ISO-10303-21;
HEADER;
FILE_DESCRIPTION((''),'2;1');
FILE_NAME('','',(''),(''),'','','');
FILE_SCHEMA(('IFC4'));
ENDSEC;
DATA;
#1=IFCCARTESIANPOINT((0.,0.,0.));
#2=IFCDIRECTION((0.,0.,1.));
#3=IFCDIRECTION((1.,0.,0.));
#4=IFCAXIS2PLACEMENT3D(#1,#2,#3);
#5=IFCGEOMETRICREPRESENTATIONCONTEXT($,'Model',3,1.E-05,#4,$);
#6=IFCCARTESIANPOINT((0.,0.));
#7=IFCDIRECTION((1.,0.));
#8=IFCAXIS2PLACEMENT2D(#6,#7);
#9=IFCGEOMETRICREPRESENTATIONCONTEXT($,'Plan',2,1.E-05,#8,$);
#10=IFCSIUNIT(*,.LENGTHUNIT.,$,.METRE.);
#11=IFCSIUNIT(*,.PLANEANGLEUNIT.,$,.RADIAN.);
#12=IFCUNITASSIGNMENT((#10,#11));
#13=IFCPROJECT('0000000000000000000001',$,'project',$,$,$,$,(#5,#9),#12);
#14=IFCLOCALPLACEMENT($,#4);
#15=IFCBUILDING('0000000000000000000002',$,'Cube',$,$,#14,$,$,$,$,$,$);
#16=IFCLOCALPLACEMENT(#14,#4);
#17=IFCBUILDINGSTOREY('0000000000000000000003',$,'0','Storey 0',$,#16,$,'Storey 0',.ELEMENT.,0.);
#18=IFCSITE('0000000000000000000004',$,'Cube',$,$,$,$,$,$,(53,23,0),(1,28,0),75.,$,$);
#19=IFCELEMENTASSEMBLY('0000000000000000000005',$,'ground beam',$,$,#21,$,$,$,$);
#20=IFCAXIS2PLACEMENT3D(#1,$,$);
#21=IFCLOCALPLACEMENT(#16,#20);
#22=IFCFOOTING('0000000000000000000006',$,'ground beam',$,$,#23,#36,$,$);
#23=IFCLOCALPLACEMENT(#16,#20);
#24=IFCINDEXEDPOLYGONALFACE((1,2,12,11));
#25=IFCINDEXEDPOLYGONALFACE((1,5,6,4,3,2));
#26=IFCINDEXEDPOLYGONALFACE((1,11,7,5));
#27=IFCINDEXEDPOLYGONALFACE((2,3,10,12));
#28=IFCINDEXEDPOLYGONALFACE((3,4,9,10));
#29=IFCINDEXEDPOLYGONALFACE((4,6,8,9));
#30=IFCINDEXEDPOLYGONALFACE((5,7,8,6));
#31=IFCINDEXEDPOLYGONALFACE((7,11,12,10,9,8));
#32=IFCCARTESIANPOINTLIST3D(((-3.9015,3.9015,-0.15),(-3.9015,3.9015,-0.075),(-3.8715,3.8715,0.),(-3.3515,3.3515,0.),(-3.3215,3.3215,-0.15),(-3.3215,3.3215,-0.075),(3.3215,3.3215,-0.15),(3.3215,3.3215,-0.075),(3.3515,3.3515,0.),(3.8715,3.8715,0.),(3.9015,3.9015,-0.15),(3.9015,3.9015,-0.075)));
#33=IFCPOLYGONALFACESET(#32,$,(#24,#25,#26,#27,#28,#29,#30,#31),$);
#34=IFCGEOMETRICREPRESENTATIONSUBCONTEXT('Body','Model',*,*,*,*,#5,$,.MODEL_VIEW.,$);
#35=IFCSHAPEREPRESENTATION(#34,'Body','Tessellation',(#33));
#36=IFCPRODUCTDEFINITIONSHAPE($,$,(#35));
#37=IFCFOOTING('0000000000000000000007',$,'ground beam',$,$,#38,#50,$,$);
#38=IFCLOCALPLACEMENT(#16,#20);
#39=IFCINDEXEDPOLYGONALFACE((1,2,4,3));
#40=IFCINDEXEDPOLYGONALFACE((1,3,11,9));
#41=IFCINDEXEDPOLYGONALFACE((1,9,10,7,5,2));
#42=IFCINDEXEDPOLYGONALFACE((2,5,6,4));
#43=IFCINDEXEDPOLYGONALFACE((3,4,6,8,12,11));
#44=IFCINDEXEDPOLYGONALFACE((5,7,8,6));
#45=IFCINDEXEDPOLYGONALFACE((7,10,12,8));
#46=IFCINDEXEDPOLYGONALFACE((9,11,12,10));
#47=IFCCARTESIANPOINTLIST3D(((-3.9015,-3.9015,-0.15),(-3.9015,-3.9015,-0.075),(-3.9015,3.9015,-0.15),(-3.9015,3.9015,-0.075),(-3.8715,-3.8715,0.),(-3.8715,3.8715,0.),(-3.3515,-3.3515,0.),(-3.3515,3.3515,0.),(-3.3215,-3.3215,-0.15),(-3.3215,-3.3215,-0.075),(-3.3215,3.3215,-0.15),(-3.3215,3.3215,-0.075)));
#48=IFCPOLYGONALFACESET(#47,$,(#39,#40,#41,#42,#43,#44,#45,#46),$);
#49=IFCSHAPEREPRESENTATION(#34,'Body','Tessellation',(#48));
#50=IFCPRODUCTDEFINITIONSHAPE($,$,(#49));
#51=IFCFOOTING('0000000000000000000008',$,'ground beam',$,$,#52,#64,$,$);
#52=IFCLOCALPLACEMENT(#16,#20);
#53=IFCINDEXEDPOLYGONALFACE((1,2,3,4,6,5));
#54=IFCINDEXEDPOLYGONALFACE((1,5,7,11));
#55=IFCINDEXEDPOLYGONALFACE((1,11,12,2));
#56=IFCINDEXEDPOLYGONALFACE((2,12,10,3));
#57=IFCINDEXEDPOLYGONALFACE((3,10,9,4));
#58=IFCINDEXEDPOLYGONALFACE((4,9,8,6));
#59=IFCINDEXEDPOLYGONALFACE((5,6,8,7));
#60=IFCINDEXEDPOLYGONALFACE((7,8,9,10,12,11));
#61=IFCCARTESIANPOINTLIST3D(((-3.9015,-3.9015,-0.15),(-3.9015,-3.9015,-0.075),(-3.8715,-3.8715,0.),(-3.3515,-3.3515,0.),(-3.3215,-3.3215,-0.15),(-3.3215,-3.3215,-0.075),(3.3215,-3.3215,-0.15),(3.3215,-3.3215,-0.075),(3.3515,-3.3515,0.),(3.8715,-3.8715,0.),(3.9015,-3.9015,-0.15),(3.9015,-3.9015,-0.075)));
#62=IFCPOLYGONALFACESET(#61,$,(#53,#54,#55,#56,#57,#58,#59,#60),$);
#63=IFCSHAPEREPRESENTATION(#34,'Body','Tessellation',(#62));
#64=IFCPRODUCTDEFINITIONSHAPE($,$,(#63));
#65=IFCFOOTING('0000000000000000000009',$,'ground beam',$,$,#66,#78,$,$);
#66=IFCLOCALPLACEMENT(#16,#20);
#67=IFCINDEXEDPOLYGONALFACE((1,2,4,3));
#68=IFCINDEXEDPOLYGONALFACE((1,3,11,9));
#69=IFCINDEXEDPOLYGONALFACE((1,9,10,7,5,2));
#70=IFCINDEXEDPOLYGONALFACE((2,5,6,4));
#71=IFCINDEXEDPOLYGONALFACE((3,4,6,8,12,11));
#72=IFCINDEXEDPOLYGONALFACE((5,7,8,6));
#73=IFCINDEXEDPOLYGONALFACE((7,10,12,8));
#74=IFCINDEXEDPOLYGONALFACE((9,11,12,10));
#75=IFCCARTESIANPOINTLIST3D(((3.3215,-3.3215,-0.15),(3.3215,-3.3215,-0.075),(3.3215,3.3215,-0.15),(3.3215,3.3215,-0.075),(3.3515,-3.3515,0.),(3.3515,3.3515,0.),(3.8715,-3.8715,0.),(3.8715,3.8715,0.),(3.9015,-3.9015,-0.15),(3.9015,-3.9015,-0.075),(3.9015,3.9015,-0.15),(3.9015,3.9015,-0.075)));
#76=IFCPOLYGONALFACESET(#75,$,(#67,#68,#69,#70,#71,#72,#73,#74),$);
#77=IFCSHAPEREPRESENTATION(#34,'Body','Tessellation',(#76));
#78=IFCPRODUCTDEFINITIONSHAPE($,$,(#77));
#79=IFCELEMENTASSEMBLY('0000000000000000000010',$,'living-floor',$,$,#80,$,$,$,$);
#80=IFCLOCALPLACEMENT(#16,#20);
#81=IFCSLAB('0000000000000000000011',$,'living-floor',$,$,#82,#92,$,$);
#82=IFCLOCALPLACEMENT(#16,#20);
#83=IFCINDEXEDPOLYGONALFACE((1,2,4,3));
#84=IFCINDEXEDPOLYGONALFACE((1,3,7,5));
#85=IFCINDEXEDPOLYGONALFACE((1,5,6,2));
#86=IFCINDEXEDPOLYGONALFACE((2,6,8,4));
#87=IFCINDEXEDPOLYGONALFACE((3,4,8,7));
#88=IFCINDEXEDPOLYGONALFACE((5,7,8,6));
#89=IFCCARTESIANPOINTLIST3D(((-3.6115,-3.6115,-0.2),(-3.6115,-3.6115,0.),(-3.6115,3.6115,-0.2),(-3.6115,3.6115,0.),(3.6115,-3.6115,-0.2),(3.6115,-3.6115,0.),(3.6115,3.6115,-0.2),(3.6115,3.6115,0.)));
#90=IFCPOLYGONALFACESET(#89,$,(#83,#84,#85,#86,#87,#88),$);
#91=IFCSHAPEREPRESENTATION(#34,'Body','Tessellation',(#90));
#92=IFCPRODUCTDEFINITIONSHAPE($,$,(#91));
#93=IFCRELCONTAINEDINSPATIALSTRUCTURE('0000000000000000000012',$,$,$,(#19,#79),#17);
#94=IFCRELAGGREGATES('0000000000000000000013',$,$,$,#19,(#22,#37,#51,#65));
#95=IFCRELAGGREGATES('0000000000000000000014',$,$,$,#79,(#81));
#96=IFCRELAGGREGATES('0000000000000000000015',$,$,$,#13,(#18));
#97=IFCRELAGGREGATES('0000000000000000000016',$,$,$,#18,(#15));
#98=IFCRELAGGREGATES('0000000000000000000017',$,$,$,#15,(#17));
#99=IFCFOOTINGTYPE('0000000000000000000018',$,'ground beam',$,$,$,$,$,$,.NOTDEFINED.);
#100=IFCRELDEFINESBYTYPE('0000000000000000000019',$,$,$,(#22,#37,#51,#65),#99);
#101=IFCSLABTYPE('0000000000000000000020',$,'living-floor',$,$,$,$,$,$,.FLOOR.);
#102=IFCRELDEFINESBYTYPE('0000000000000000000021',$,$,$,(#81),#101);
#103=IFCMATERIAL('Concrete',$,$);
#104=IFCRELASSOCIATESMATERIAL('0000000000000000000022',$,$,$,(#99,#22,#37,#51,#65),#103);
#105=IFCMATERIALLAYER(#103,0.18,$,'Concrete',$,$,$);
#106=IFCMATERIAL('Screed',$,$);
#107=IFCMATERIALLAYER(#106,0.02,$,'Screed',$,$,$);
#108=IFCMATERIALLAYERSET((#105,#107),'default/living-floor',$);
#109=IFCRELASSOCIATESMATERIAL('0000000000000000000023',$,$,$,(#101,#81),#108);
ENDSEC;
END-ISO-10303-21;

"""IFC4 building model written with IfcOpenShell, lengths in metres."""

from ifc_helpers import new_model, si_unit, frame, origin, origin_with_axes, origin_2d_with_axis, place, context, subcontext, project, spatial, polyline, outline, extrude, clip, halfspace, material, layer, layer_set, layer_usage, material_profile, profile_set, profile_usage, type_object, element, aggregate, save


model = new_model("IFC4")

# Units and contexts
model_context = context("Model", 3, precision=1e-05, world=origin_with_axes())
plan_context = context("Plan", 2, precision=1e-05, world=origin_2d_with_axis())
body_context = subcontext(model_context, "Body", "Model", "MODEL_VIEW")
ifc_project = project(units=[si_unit("LENGTHUNIT", "METRE"), si_unit("PLANEANGLEUNIT", "RADIAN")], contexts=[model_context, plan_context])

# Site, building, storey
site = spatial("IfcSite", under=ifc_project, Name="Cube", RefLatitude=(53, 23, 0), RefLongitude=(1, 28, 0), RefElevation=75.0)
building_placement = place(None, origin_with_axes())
building = spatial("IfcBuilding", under=site, at=building_placement, Name="Cube")
storey_placement = place(building_placement, origin_with_axes())
storey = spatial("IfcBuildingStorey", under=building, at=storey_placement, Name="0", Description="Storey 0", LongName="Storey 0", CompositionType="ELEMENT", Elevation=0.0)

# Element assembly, footings
assembly_1_placement = place(storey_placement, origin_with_axes())
assembly_1 = element("IfcElementAssembly", 1, at=assembly_1_placement, inside=storey, Name="ground beam")
ifc_material_1 = material(Name="Concrete")
ifc_material_profile = material_profile(ifc_material_1, outline(polyline([(-0.26, 0.0), (-0.29, -0.075), (-0.29, -0.15), (0.29, -0.15), (0.29, -0.075), (0.26, 0.0), (-0.26, 0.0)])))
ifc_profile_set = profile_set([ifc_material_profile])
ifc_profile_usage_1 = profile_usage(ifc_profile_set)
footing_type = type_object("IfcFootingType", Name="ground beam", PredefinedType="NOTDEFINED", material=ifc_profile_set)
footing_1_placement = place(assembly_1_placement, frame((-4.6115, 3.6115, 0.0), z_axis=(1.0, 0.0, 0.0), x_axis=(0.0, 1.0, 0.0)))
footing_1 = element("IfcFooting", 2, at=footing_1_placement, type_object=footing_type, material=ifc_profile_usage_1, Name="ground beam", context=body_context, shape_type="Clipping", body=[
    clip(clip(extrude(outline(polyline([(-0.26, 0.0), (-0.29, -0.075), (-0.29, -0.15), (0.29, -0.15), (0.29, -0.075), (0.26, 0.0), (-0.26, 0.0)])), origin_with_axes(), (0.0, 0.0, 1.0), 9.223), halfspace(frame((0.0, 0.0, 1.0), z_axis=(-0.707107, 0.0, -0.707107), x_axis=(0.0, 1.0, 0.0)), False)), halfspace(frame((0.0, 0.0, 8.223), z_axis=(-0.707107, 0.0, 0.707107), x_axis=(0.0, 1.0, 0.0)), False)),
])
ifc_profile_usage_2 = profile_usage(ifc_profile_set)
footing_2_placement = place(assembly_1_placement, frame((-3.6115, -4.6115, 0.0), z_axis=(0.0, 1.0, 0.0), x_axis=(-1.0, 0.0, 0.0)))
footing_2 = element("IfcFooting", 3, at=footing_2_placement, type_object=footing_type, material=ifc_profile_usage_2, Name="ground beam", context=body_context, shape_type="Clipping", body=[
    clip(clip(extrude(outline(polyline([(-0.26, 0.0), (-0.29, -0.075), (-0.29, -0.15), (0.29, -0.15), (0.29, -0.075), (0.26, 0.0), (-0.26, 0.0)])), origin_with_axes(), (0.0, 0.0, 1.0), 9.223), halfspace(frame((0.0, 0.0, 1.0), z_axis=(-0.707107, 0.0, -0.707107), x_axis=(0.0, 1.0, 0.0)), False)), halfspace(frame((0.0, 0.0, 8.223), z_axis=(-0.707107, 0.0, 0.707107), x_axis=(0.0, 1.0, 0.0)), False)),
])
ifc_profile_usage_3 = profile_usage(ifc_profile_set)
footing_3_placement = place(assembly_1_placement, frame((4.6115, -3.6115, 0.0), z_axis=(-1.0, 0.0, 0.0), x_axis=(0.0, -1.0, 0.0)))
footing_3 = element("IfcFooting", 4, at=footing_3_placement, type_object=footing_type, material=ifc_profile_usage_3, Name="ground beam", context=body_context, shape_type="Clipping", body=[
    clip(clip(extrude(outline(polyline([(-0.26, 0.0), (-0.29, -0.075), (-0.29, -0.15), (0.29, -0.15), (0.29, -0.075), (0.26, 0.0), (-0.26, 0.0)])), origin_with_axes(), (0.0, 0.0, 1.0), 9.223), halfspace(frame((0.0, 0.0, 1.0), z_axis=(-0.707107, 0.0, -0.707107), x_axis=(0.0, 1.0, 0.0)), False)), halfspace(frame((0.0, 0.0, 8.223), z_axis=(-0.707107, 0.0, 0.707107), x_axis=(0.0, 1.0, 0.0)), False)),
])
ifc_profile_usage_4 = profile_usage(ifc_profile_set)
footing_4_placement = place(assembly_1_placement, frame((3.6115, 4.6115, 0.0), z_axis=(0.0, -1.0, 0.0), x_axis=(1.0, 0.0, 0.0)))
footing_4 = element("IfcFooting", 5, at=footing_4_placement, type_object=footing_type, material=ifc_profile_usage_4, Name="ground beam", context=body_context, shape_type="Clipping", body=[
    clip(clip(extrude(outline(polyline([(-0.26, 0.0), (-0.29, -0.075), (-0.29, -0.15), (0.29, -0.15), (0.29, -0.075), (0.26, 0.0), (-0.26, 0.0)])), origin_with_axes(), (0.0, 0.0, 1.0), 9.223), halfspace(frame((0.0, 0.0, 1.0), z_axis=(-0.707107, 0.0, -0.707107), x_axis=(0.0, 1.0, 0.0)), False)), halfspace(frame((0.0, 0.0, 8.223), z_axis=(-0.707107, 0.0, 0.707107), x_axis=(0.0, 1.0, 0.0)), False)),
])
aggregate(assembly_1, [footing_1, footing_2, footing_3, footing_4])

# Element assembly, slab
assembly_2_placement = place(storey_placement, origin_with_axes())
assembly_2 = element("IfcElementAssembly", 6, at=assembly_2_placement, inside=storey, Name="living-floor")
ifc_layer_1 = layer(ifc_material_1, 0.18, Name="Concrete")
ifc_material_2 = material(Name="Screed")
ifc_layer_2 = layer(ifc_material_2, 0.02, Name="Screed")
ifc_layer_set_1 = layer_set([ifc_layer_1, ifc_layer_2], Name="default/living-floor")
ifc_layer_usage_1 = layer_usage(ifc_layer_set_1, "AXIS3", "POSITIVE", 0.0)
slab_type = type_object("IfcSlabType", Name="living-floor", PredefinedType="FLOOR", material=ifc_layer_set_1)
slab_placement = place(assembly_2_placement, frame((-3.6115, 3.6115, -0.2), z_axis=(0.0, 0.0, -1.0), x_axis=(0.0, 1.0, 0.0)))
slab = element("IfcSlab", 7, at=slab_placement, type_object=slab_type, material=ifc_layer_usage_1, Name="living-floor", context=body_context, shape_type="SweptSolid", body=[
    extrude(outline(polyline([(0.0, 0.0), (0.0, 7.223), (-7.223, 7.223), (-7.223, 0.0), (0.0, 0.0)])), origin(), (0.0, 0.0, -1.0), 0.2),
])
aggregate(assembly_2, [slab])

save(model, "model.ifc")
